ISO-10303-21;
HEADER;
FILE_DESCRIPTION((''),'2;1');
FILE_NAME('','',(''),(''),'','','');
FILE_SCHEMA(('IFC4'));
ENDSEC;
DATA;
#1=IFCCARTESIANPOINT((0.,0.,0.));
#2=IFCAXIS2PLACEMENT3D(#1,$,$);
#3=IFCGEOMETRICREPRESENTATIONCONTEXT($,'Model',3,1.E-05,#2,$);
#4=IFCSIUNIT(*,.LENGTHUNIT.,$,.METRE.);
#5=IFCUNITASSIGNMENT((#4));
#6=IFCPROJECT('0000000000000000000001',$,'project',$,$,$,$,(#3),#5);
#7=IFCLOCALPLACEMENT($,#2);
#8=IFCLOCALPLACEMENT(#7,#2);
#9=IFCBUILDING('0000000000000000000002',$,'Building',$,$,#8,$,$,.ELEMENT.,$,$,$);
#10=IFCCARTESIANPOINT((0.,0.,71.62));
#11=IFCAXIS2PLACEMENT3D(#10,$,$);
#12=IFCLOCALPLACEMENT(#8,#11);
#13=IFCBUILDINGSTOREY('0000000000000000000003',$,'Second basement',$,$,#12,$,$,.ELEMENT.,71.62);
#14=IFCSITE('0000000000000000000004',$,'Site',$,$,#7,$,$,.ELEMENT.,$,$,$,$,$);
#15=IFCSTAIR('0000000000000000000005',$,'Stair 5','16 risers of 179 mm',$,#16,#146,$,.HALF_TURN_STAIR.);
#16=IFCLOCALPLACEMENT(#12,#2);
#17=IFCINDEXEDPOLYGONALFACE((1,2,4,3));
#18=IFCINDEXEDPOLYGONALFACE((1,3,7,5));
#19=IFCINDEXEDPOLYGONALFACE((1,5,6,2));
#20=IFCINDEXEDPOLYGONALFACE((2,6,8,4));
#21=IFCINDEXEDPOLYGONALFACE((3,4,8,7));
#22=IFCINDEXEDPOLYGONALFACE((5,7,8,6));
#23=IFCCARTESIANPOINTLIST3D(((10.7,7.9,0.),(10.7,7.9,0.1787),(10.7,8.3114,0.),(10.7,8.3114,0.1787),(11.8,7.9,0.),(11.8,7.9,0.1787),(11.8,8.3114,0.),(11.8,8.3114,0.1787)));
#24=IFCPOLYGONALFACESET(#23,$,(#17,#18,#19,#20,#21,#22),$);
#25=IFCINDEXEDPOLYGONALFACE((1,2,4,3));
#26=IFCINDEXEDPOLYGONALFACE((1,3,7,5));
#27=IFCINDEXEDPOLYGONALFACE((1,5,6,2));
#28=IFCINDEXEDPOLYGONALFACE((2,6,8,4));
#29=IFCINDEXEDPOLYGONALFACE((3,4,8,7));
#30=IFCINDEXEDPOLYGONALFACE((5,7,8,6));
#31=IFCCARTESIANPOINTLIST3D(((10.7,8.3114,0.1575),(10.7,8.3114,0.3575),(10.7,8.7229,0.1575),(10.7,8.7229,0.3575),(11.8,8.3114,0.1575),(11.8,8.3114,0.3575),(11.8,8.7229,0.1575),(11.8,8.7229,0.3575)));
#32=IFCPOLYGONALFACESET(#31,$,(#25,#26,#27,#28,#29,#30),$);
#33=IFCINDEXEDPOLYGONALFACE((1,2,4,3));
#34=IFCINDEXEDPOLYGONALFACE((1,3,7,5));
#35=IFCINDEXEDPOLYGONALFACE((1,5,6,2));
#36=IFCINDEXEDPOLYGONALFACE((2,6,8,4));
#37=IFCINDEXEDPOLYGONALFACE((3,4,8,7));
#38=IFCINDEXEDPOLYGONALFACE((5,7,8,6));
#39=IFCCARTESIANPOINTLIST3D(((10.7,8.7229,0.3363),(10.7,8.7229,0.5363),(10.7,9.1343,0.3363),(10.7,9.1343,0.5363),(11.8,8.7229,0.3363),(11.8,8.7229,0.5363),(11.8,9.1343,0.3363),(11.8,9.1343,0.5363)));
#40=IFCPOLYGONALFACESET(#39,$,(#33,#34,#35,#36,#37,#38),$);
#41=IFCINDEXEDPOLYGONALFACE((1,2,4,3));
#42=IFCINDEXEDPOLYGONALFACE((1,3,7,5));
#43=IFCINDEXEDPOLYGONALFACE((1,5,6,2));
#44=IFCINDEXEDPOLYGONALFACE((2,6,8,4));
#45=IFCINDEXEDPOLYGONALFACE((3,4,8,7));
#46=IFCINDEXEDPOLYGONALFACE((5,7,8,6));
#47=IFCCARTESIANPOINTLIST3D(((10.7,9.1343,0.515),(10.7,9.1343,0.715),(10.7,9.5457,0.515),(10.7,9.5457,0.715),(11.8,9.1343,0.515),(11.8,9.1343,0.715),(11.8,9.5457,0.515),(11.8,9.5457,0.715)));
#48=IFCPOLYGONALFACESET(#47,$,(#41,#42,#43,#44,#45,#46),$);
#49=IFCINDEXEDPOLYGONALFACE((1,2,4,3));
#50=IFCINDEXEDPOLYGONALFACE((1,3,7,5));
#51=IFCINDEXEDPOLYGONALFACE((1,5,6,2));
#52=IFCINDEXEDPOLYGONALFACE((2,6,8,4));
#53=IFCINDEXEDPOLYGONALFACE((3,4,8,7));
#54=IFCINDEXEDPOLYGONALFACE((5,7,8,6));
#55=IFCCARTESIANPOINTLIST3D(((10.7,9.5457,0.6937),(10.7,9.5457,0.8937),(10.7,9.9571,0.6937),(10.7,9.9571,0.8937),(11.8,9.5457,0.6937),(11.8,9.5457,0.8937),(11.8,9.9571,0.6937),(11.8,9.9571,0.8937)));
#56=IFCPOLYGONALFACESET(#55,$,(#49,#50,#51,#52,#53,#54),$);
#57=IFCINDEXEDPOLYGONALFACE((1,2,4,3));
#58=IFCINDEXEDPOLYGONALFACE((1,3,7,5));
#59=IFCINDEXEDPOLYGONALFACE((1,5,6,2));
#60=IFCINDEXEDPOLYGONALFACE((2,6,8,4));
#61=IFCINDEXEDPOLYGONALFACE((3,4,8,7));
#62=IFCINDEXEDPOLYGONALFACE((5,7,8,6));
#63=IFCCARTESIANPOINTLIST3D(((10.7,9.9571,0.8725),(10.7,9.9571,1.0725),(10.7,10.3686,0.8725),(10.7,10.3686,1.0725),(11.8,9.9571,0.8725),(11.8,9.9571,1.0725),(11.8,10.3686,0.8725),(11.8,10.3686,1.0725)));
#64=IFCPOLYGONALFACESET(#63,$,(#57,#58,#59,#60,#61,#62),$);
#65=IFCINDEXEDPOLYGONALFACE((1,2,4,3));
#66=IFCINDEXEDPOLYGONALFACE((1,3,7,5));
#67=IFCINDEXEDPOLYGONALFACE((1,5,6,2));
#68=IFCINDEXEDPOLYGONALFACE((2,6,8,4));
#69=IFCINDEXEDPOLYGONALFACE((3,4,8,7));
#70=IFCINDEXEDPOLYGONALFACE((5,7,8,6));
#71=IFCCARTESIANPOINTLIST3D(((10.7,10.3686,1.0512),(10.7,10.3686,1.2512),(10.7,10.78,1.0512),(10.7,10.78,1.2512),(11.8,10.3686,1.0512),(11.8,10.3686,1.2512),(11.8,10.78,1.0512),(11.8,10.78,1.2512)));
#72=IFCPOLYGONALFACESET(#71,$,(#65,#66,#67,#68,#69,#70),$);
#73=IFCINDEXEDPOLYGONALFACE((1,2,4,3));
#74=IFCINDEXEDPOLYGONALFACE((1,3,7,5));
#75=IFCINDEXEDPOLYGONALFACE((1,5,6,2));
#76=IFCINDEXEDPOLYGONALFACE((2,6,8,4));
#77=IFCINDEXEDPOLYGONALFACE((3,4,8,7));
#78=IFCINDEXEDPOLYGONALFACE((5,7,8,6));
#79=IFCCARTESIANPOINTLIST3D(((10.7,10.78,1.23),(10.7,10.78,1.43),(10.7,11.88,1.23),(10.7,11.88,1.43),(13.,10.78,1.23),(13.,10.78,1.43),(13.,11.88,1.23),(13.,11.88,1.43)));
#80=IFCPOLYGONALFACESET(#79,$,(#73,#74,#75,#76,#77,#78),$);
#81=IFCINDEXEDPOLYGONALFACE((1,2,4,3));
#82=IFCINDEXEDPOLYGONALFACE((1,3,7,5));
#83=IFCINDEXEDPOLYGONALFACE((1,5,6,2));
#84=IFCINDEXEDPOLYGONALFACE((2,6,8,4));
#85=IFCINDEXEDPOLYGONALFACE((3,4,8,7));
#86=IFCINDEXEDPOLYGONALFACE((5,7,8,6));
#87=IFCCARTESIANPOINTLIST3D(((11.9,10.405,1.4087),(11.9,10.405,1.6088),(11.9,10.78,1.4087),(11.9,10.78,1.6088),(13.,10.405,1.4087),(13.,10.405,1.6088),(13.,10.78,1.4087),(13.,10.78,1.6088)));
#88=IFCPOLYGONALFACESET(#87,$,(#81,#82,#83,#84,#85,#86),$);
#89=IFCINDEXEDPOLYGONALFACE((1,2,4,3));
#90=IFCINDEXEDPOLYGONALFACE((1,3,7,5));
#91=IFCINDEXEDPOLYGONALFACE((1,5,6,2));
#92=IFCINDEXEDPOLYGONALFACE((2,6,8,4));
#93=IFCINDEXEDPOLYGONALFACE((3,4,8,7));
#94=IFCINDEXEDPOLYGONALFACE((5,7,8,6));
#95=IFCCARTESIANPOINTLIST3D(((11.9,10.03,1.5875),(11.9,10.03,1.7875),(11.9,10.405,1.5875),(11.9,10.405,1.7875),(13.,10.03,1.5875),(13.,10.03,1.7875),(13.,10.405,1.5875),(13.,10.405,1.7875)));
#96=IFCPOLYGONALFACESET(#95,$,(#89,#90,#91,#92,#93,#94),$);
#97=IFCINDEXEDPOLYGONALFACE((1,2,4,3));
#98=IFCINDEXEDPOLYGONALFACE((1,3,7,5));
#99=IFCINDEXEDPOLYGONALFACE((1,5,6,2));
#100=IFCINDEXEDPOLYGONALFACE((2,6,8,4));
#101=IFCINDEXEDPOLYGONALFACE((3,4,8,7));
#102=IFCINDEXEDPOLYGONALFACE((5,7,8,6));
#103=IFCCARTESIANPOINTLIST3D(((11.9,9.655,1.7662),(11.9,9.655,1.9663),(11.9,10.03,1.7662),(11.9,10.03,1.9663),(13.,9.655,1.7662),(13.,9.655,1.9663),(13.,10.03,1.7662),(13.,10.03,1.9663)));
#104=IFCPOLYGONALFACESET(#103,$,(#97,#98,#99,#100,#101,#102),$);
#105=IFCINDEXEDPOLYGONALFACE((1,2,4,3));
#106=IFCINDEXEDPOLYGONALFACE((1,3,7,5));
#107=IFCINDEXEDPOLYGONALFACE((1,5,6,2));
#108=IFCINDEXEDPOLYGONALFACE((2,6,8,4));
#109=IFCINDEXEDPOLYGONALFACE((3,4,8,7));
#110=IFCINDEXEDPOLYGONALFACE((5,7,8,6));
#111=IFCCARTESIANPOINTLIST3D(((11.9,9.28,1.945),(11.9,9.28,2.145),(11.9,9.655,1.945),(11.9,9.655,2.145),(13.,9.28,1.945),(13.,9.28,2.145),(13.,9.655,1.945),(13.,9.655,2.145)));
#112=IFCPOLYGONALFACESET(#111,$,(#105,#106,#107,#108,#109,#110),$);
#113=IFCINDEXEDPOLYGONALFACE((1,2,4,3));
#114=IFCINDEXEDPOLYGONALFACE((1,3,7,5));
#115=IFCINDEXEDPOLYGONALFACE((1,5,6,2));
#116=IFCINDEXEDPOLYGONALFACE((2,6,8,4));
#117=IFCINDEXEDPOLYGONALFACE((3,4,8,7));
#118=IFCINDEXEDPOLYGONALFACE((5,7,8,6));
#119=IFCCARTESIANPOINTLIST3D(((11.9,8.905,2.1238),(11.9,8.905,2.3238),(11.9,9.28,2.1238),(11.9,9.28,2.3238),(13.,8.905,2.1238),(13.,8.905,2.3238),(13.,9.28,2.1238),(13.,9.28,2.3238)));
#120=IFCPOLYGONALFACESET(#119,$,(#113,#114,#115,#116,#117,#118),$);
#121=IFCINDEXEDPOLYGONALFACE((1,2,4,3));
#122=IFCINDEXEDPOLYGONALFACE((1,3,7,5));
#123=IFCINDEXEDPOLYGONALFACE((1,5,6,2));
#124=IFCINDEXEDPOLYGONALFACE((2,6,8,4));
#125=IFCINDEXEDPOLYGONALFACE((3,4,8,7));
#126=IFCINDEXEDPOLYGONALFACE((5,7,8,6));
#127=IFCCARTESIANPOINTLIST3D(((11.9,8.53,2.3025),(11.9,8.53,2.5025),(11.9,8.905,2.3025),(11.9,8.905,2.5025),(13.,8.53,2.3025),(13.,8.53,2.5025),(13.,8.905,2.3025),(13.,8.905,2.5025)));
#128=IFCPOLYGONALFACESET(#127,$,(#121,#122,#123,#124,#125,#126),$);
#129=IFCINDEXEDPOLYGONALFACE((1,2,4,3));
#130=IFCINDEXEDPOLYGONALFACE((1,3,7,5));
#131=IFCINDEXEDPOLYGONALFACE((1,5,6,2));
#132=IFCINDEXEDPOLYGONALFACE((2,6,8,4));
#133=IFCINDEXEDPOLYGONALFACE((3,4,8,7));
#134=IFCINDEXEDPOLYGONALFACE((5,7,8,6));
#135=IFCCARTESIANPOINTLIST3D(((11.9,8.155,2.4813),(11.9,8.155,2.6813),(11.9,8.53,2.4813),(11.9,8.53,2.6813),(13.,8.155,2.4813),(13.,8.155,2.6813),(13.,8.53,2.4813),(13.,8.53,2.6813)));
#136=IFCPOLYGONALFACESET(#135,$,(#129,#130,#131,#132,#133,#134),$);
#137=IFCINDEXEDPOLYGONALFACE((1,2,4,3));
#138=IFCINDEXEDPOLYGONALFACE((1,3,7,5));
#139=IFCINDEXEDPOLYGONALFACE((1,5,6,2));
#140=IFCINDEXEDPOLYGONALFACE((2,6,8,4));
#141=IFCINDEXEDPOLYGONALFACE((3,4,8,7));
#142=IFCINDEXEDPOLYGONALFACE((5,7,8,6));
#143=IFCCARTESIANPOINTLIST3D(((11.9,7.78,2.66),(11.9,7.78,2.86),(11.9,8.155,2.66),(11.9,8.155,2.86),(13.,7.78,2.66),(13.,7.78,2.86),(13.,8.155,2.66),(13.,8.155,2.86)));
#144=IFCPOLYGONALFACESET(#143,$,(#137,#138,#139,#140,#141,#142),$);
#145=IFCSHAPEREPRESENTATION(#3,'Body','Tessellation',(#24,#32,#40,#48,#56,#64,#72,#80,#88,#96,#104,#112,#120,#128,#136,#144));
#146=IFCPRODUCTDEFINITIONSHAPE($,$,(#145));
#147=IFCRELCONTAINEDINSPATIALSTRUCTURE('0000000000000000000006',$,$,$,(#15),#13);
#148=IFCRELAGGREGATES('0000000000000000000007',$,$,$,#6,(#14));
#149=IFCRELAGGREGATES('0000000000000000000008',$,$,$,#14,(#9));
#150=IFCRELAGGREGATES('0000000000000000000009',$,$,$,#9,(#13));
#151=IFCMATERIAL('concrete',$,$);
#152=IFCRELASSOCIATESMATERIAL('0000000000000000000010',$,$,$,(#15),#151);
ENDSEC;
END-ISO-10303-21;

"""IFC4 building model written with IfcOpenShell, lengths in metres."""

from ifc_helpers import new_model, si_unit, frame, origin, place, context, project, spatial, polyline, outline, extrude, material, element, save


model = new_model("IFC4")

# Units and contexts
model_context = context("Model", 3, precision=1e-05, world=origin())
ifc_project = project(units=[si_unit("LENGTHUNIT", "METRE")], contexts=[model_context])

# Site, building, storey
site_placement = place(None, origin())
site = spatial("IfcSite", under=ifc_project, at=site_placement, Name="Site", CompositionType="ELEMENT")
building_placement = place(site_placement, origin())
building = spatial("IfcBuilding", under=site, at=building_placement, Name="Building", CompositionType="ELEMENT")
storey_placement = place(building_placement, frame((0.0, 0.0, 71.62)))
storey = spatial("IfcBuildingStorey", under=building, at=storey_placement, Name="Second basement", CompositionType="ELEMENT", Elevation=71.62)

# Shared definitions
ifc_material = material(Name="concrete")

# Stair
stair_1_placement = place(storey_placement, frame((11.25, 7.9, 0.0), z_axis=(0.0, 0.0, 1.0), x_axis=(0.0, 1.0, 0.0)))
element("IfcStair", 1, at=stair_1_placement, inside=storey, material=ifc_material, Name="Stair 5", Description="16 risers of 179 mm", PredefinedType="HALF_TURN_STAIR", context=model_context, shape_type="SweptSolid", body=[
    extrude(outline(polyline([(0.0, -0.55), (0.4114, -0.55), (0.4114, 0.55), (0.0, 0.55), (0.0, -0.55)])), origin(), (0.0, 0.0, 1.0), 0.1787),
    extrude(outline(polyline([(0.4114, -0.55), (0.8229, -0.55), (0.8229, 0.55), (0.4114, 0.55), (0.4114, -0.55)])), frame((0.0, 0.0, 0.1575)), (0.0, 0.0, 1.0), 0.2),
    extrude(outline(polyline([(0.8229, -0.55), (1.2343, -0.55), (1.2343, 0.55), (0.8229, 0.55), (0.8229, -0.55)])), frame((0.0, 0.0, 0.3362)), (0.0, 0.0, 1.0), 0.2),
    extrude(outline(polyline([(1.2343, -0.55), (1.6457, -0.55), (1.6457, 0.55), (1.2343, 0.55), (1.2343, -0.55)])), frame((0.0, 0.0, 0.515)), (0.0, 0.0, 1.0), 0.2),
    extrude(outline(polyline([(1.6457, -0.55), (2.0571, -0.55), (2.0571, 0.55), (1.6457, 0.55), (1.6457, -0.55)])), frame((0.0, 0.0, 0.6937)), (0.0, 0.0, 1.0), 0.2),
    extrude(outline(polyline([(2.0571, -0.55), (2.4686, -0.55), (2.4686, 0.55), (2.0571, 0.55), (2.0571, -0.55)])), frame((0.0, 0.0, 0.8725)), (0.0, 0.0, 1.0), 0.2),
    extrude(outline(polyline([(2.4686, -0.55), (2.88, -0.55), (2.88, 0.55), (2.4686, 0.55), (2.4686, -0.55)])), frame((0.0, 0.0, 1.0513)), (0.0, 0.0, 1.0), 0.2),
    extrude(outline(polyline([(2.88, -1.75), (3.98, -1.75), (3.98, 0.55), (2.88, 0.55), (2.88, -1.75)])), frame((0.0, 0.0, 1.23)), (0.0, 0.0, 1.0), 0.2),
    extrude(outline(polyline([(2.505, -1.75), (2.88, -1.75), (2.88, -0.65), (2.505, -0.65), (2.505, -1.75)])), frame((0.0, 0.0, 1.4087)), (0.0, 0.0, 1.0), 0.2),
    extrude(outline(polyline([(2.13, -1.75), (2.505, -1.75), (2.505, -0.65), (2.13, -0.65), (2.13, -1.75)])), frame((0.0, 0.0, 1.5875)), (0.0, 0.0, 1.0), 0.2),
    extrude(outline(polyline([(1.755, -1.75), (2.13, -1.75), (2.13, -0.65), (1.755, -0.65), (1.755, -1.75)])), frame((0.0, 0.0, 1.7663)), (0.0, 0.0, 1.0), 0.2),
    extrude(outline(polyline([(1.38, -1.75), (1.755, -1.75), (1.755, -0.65), (1.38, -0.65), (1.38, -1.75)])), frame((0.0, 0.0, 1.945)), (0.0, 0.0, 1.0), 0.2),
    extrude(outline(polyline([(1.005, -1.75), (1.38, -1.75), (1.38, -0.65), (1.005, -0.65), (1.005, -1.75)])), frame((0.0, 0.0, 2.1237)), (0.0, 0.0, 1.0), 0.2),
    extrude(outline(polyline([(0.63, -1.75), (1.005, -1.75), (1.005, -0.65), (0.63, -0.65), (0.63, -1.75)])), frame((0.0, 0.0, 2.3025)), (0.0, 0.0, 1.0), 0.2),
    extrude(outline(polyline([(0.255, -1.75), (0.63, -1.75), (0.63, -0.65), (0.255, -0.65), (0.255, -1.75)])), frame((0.0, 0.0, 2.4813)), (0.0, 0.0, 1.0), 0.2),
    extrude(outline(polyline([(-0.12, -1.75), (0.255, -1.75), (0.255, -0.65), (-0.12, -0.65), (-0.12, -1.75)])), frame((0.0, 0.0, 2.66)), (0.0, 0.0, 1.0), 0.2),
])

save(model, "model.ifc")
